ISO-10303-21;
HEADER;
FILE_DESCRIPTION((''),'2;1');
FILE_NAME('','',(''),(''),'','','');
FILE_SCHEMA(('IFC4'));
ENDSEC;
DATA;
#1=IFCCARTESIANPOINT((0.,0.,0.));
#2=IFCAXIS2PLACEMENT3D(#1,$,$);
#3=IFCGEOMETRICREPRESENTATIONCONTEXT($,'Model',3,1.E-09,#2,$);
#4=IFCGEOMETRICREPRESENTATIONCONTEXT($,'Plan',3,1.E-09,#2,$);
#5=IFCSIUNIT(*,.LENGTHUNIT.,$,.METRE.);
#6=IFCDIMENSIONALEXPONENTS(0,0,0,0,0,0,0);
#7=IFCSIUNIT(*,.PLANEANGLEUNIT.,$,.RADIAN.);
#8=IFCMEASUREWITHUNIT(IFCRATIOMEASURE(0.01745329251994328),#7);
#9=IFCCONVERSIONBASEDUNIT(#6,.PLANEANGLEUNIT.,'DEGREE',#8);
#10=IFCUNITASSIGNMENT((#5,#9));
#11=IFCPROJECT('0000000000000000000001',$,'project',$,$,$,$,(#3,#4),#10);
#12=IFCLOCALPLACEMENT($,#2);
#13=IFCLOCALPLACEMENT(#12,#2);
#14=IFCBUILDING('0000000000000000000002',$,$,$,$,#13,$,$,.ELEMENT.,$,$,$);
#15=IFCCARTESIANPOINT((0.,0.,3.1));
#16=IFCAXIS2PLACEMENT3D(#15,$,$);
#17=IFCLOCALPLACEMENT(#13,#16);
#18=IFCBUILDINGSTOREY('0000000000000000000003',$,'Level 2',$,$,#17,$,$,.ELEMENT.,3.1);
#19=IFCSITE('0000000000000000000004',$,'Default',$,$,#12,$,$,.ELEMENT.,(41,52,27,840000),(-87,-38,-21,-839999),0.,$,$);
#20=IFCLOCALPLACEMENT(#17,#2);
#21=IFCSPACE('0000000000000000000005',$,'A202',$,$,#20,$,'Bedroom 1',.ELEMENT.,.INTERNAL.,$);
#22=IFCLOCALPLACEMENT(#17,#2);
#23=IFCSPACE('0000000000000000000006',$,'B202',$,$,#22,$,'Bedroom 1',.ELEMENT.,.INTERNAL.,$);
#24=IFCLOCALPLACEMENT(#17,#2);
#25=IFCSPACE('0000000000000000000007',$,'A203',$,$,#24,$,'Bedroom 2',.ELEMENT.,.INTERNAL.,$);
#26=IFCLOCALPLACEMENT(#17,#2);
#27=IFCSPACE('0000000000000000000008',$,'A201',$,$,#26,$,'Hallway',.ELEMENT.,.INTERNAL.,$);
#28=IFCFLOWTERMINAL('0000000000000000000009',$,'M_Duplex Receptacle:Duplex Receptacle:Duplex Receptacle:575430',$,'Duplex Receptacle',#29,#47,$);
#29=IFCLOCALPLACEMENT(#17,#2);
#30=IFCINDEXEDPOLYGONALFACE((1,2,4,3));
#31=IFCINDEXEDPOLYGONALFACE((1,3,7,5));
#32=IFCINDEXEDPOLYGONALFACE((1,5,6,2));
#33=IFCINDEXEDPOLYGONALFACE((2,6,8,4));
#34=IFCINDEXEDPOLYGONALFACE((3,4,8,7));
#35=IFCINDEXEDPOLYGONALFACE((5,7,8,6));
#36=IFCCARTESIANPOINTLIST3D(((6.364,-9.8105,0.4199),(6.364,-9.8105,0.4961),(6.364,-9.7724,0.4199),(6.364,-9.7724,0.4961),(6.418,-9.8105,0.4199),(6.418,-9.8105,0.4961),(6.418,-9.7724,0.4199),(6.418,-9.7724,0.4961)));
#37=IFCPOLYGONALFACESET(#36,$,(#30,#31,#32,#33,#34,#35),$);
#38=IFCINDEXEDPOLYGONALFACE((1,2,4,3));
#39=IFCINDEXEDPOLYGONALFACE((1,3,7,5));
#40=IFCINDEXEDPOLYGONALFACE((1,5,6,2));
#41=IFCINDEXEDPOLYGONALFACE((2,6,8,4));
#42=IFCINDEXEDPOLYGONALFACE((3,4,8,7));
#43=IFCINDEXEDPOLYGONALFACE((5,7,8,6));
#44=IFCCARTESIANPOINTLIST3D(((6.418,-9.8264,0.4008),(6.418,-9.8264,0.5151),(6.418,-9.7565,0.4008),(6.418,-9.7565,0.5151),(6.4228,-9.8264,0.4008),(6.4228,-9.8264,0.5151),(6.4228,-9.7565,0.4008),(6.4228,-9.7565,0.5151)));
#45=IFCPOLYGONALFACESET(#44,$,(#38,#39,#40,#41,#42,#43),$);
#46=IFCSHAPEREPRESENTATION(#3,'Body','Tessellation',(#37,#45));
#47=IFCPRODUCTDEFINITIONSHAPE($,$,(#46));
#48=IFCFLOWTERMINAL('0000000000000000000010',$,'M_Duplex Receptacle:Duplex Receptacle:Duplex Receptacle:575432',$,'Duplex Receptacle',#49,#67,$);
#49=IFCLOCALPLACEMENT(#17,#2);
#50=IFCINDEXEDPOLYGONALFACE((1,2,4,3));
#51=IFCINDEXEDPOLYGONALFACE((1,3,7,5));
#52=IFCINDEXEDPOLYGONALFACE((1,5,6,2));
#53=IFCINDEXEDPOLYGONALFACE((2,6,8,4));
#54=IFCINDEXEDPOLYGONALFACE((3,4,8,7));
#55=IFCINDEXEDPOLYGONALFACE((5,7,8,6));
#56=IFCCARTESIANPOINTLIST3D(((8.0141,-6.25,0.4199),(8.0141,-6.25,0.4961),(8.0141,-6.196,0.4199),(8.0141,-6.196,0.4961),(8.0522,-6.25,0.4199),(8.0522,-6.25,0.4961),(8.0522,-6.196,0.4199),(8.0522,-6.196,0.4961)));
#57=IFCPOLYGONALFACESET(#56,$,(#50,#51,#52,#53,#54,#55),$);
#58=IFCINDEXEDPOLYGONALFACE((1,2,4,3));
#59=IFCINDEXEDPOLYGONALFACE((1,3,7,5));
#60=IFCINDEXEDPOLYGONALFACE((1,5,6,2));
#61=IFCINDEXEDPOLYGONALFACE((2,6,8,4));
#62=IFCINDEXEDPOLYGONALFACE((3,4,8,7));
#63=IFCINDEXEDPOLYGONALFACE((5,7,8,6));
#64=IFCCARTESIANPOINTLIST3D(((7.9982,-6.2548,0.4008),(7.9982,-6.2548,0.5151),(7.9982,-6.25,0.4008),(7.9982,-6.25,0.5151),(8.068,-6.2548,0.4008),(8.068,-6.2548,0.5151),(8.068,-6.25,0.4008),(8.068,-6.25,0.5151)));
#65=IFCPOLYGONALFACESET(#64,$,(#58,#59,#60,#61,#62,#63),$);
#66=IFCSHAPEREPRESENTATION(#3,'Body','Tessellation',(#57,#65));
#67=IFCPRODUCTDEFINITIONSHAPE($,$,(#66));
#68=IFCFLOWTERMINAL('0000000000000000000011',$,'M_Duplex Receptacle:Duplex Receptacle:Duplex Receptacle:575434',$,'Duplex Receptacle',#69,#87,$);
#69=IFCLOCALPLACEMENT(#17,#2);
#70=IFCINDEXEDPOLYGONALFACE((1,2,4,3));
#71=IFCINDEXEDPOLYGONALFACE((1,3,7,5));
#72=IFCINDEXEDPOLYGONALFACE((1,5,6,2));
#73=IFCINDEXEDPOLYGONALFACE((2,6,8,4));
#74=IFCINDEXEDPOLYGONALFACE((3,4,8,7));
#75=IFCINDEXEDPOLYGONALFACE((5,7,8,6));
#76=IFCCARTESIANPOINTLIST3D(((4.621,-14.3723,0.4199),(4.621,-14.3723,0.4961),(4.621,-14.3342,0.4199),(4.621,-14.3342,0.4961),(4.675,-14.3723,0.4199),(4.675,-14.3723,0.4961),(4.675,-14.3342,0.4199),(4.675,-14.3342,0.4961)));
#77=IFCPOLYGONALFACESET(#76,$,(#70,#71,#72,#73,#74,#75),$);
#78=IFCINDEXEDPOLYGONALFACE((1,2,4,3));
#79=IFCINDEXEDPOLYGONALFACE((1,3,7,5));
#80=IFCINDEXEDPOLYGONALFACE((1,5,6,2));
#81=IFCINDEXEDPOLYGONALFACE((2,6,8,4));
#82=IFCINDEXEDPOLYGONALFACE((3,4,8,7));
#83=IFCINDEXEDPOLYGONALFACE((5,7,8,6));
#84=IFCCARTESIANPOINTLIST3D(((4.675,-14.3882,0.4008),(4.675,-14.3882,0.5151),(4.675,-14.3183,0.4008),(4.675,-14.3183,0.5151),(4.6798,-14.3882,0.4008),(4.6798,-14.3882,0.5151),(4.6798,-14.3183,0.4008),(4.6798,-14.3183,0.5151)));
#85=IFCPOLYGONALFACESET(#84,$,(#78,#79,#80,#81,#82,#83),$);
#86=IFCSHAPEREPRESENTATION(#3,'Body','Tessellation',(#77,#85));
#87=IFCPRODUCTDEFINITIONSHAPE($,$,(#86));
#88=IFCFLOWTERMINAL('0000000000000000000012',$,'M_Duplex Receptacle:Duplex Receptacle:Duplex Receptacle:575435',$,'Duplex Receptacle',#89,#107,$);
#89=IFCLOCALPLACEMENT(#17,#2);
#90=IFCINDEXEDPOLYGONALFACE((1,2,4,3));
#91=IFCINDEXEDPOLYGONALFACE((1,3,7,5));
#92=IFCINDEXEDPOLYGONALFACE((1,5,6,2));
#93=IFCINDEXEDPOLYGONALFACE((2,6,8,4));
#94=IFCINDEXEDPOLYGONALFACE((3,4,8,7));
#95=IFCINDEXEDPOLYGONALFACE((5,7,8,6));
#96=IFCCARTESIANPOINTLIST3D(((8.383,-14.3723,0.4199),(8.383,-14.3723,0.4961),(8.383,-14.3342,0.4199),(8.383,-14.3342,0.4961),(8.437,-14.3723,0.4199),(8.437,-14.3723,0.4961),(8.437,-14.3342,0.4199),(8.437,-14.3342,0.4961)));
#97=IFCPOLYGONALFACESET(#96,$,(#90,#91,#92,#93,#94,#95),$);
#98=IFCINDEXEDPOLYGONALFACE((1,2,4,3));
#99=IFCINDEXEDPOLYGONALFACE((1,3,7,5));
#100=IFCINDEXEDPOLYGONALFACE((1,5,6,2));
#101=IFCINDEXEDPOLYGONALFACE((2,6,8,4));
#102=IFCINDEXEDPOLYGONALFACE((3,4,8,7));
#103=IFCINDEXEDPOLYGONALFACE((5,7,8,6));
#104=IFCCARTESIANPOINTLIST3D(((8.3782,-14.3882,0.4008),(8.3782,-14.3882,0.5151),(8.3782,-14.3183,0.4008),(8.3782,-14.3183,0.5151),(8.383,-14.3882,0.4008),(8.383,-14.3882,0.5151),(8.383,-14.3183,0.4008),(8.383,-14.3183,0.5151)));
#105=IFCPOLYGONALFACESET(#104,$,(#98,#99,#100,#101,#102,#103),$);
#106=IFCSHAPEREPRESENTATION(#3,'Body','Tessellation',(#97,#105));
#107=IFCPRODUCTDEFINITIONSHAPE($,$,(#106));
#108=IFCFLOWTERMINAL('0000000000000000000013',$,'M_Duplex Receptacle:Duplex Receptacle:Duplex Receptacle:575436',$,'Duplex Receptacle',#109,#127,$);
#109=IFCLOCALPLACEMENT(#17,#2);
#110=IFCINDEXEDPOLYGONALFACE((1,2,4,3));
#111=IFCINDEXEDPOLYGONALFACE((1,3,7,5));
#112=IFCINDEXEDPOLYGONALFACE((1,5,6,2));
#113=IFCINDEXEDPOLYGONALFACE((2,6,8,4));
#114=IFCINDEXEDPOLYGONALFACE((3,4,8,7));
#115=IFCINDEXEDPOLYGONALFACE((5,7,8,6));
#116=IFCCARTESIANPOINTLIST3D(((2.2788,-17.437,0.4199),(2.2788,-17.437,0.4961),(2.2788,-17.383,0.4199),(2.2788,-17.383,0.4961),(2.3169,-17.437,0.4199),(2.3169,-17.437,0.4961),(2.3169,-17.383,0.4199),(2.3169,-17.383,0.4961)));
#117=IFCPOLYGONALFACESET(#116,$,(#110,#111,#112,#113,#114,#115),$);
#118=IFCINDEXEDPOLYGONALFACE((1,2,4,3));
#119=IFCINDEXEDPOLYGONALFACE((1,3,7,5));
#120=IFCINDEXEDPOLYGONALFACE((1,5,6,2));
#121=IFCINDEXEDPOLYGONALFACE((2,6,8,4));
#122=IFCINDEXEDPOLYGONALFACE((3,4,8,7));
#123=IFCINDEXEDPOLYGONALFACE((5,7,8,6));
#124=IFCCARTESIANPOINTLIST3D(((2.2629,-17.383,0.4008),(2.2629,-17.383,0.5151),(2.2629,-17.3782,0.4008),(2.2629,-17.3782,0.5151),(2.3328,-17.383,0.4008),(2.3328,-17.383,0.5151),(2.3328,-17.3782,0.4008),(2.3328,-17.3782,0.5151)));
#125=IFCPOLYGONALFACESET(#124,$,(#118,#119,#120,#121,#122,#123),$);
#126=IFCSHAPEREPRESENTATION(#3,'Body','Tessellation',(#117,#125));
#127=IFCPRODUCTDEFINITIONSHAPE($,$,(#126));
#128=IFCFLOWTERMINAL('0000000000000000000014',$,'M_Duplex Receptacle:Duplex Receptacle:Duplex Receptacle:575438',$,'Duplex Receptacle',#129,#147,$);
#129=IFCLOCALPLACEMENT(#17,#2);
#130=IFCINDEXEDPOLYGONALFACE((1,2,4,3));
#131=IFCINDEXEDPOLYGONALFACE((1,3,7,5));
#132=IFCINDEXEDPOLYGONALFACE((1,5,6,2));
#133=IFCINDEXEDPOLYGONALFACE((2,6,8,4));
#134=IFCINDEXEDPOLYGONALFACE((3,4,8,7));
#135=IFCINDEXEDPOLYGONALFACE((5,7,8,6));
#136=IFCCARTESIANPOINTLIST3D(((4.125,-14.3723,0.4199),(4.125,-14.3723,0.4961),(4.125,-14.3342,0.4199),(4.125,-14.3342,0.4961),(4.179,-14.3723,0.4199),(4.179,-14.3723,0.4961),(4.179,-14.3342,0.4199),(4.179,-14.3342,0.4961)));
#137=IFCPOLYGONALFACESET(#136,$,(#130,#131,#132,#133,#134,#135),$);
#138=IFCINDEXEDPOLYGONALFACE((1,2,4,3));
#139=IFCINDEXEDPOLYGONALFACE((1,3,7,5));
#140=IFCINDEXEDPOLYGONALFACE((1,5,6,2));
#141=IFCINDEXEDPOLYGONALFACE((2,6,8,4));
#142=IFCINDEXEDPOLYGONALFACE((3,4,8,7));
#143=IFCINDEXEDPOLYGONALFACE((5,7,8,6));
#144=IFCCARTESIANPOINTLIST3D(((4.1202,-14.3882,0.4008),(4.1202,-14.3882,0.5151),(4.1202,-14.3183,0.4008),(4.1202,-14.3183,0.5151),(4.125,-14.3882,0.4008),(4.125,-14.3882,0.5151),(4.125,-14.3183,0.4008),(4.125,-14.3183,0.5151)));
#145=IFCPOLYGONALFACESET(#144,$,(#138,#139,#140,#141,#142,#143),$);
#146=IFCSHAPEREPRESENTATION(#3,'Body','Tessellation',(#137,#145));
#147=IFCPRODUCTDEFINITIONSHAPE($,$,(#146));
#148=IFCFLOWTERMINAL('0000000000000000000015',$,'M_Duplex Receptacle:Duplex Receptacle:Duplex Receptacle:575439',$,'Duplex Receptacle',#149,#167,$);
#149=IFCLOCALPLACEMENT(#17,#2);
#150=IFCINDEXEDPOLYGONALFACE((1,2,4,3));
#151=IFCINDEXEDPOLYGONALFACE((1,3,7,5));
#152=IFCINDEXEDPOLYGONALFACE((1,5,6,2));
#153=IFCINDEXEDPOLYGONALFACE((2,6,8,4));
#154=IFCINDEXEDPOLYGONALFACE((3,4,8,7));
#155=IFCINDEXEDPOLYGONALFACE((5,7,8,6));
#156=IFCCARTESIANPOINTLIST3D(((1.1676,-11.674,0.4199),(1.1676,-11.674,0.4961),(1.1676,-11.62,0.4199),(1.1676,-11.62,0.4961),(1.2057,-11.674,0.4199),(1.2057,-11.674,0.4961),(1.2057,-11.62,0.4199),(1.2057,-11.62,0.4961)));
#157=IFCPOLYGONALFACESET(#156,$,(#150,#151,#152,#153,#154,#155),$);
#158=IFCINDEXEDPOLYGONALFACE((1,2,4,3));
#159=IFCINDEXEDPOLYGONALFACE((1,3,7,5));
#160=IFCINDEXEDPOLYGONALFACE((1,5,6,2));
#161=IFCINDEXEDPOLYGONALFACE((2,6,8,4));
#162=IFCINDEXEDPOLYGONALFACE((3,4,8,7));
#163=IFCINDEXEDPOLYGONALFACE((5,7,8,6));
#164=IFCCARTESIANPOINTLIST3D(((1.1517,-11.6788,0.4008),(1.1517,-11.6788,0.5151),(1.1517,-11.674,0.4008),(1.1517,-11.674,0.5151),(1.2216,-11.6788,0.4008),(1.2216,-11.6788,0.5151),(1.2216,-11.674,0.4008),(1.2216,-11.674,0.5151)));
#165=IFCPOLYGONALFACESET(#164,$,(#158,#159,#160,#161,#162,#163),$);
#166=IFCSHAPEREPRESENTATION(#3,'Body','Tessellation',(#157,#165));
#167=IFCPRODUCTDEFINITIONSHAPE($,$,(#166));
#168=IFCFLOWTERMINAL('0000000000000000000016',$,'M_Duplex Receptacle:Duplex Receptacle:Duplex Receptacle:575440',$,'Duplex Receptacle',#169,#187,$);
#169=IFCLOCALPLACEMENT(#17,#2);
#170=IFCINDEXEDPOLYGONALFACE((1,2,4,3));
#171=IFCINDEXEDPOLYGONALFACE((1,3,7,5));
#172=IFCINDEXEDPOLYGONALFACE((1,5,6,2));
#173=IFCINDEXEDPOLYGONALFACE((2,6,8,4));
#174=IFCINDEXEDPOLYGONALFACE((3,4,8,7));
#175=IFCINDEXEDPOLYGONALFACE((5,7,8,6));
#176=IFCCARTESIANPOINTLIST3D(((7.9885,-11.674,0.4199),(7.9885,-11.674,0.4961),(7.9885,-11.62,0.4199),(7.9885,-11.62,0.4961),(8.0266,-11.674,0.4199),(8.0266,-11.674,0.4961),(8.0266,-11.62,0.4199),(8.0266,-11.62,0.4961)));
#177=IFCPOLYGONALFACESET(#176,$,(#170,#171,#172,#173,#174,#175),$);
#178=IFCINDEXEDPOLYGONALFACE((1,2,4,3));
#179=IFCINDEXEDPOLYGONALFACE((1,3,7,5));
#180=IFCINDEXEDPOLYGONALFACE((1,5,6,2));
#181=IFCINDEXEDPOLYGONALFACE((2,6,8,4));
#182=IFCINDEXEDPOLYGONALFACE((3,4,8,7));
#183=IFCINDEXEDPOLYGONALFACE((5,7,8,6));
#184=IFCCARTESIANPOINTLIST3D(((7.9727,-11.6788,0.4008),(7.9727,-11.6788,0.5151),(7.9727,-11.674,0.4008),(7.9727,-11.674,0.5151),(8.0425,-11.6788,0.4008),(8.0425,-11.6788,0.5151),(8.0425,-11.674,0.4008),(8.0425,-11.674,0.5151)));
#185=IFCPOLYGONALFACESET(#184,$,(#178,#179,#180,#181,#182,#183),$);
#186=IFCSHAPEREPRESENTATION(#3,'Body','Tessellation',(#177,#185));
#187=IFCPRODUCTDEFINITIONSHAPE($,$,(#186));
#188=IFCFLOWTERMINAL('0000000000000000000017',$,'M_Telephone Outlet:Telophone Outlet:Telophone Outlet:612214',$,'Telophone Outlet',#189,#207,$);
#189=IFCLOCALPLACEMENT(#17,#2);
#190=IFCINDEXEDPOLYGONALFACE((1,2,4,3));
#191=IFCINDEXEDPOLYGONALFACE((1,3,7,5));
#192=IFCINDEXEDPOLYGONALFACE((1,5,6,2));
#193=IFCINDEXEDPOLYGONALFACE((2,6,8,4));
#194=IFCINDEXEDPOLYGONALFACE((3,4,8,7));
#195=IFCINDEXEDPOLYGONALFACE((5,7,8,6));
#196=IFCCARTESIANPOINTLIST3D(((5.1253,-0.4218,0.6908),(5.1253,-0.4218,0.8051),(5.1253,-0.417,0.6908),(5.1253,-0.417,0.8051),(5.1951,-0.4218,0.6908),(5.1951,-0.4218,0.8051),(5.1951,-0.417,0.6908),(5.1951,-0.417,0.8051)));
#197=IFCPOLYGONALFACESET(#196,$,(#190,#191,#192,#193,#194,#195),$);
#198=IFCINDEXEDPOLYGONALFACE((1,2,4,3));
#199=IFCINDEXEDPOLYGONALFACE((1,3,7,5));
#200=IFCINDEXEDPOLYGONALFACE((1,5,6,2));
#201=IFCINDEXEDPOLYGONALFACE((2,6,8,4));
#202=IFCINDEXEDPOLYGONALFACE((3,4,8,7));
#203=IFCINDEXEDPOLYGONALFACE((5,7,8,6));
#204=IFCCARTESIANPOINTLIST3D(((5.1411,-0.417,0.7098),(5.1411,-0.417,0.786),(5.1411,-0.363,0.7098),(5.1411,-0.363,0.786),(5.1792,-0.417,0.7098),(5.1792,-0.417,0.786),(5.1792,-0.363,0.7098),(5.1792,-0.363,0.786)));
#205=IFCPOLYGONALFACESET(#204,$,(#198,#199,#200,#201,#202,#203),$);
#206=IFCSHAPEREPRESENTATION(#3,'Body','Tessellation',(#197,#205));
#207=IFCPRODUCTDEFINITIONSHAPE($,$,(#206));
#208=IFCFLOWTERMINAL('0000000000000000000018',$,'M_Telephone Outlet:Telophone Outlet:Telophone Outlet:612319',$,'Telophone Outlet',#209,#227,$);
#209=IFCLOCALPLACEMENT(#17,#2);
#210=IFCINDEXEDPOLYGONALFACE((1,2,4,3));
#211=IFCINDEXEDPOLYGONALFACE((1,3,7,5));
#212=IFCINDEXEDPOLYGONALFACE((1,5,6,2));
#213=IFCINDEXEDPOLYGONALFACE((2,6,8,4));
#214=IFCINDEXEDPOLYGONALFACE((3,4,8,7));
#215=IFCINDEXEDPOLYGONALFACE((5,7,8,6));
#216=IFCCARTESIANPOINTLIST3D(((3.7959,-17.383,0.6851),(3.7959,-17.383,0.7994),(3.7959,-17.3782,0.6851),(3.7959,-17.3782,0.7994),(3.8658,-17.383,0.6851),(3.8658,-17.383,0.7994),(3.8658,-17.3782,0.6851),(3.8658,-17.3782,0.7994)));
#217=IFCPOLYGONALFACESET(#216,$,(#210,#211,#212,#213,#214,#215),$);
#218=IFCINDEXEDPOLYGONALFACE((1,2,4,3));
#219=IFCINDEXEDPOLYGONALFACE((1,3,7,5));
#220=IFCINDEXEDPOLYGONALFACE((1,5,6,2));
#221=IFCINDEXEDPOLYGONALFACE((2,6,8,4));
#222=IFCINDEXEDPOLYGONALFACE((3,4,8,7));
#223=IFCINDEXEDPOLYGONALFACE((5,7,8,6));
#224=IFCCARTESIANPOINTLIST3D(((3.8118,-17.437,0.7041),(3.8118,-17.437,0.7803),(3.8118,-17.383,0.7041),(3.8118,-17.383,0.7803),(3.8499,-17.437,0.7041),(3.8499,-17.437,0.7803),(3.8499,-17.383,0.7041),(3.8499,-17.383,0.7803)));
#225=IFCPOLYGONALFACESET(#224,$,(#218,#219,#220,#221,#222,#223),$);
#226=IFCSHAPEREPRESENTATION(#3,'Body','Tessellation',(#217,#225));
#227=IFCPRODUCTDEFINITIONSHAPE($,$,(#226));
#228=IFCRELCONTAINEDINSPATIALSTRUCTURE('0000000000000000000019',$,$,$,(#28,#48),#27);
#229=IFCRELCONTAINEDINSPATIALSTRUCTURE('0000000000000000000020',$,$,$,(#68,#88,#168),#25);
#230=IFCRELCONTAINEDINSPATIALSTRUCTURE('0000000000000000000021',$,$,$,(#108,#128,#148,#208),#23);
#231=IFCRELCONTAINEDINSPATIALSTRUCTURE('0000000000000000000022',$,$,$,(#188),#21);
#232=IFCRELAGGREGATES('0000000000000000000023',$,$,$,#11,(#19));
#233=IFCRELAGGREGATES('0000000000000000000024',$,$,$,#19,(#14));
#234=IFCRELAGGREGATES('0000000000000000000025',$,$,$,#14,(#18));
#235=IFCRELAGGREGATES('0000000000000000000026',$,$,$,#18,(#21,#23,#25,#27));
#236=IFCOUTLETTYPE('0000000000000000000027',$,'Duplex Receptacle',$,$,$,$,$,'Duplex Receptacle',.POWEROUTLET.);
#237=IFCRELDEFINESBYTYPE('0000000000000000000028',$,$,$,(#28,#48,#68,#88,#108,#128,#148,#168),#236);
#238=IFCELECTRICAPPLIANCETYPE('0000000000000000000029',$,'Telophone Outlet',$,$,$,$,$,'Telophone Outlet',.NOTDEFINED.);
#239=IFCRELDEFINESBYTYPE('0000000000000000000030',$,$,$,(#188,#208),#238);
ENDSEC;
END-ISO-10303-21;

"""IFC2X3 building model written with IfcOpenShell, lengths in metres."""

from ifc_helpers import new_model, entity, si_unit, converted_unit, frame, origin, origin_2d_with_axis, place, context, project, spatial, rectangle, extrude, source, transform, mapped, type_object, type_shapes, element, save


model = new_model("IFC2X3")

# Units and contexts
model_context = context("Model", 3, precision=1e-09, world=origin())
plan_context = context("Plan", 3, precision=1e-09, world=origin())
ifc_project = project(units=[si_unit("LENGTHUNIT", "METRE"), converted_unit("PLANEANGLEUNIT", "DEGREE", entity("IfcRatioMeasure", 0.01745329251994328), si_unit("PLANEANGLEUNIT", "RADIAN"), dimensions=[0, 0, 0, 0, 0, 0, 0])], contexts=[model_context, plan_context])

# Site, building, storey, space
site_placement = place(None, origin())
site = spatial("IfcSite", under=ifc_project, at=site_placement, Name="Default", CompositionType="ELEMENT", RefLatitude=(41, 52, 27, 840000), RefLongitude=(-87, -38, -21, -839999), RefElevation=0.0)
building_placement = place(site_placement, origin())
building = spatial("IfcBuilding", under=site, at=building_placement, CompositionType="ELEMENT")
storey_placement = place(building_placement, frame((0.0, 0.0, 3.1)))
storey = spatial("IfcBuildingStorey", under=building, at=storey_placement, Name="Level 2", CompositionType="ELEMENT", Elevation=3.1)
space_1_placement = place(storey_placement, origin())
space_1 = spatial("IfcSpace", under=storey, at=space_1_placement, Name="A202", LongName="Bedroom 1", CompositionType="ELEMENT", InteriorOrExteriorSpace="INTERNAL")

# Shared definitions
space_2_placement = place(storey_placement, origin())
space_2 = spatial("IfcSpace", under=storey, at=space_2_placement, Name="B202", LongName="Bedroom 1", CompositionType="ELEMENT", InteriorOrExteriorSpace="INTERNAL")

# Shared definitions
space_3_placement = place(storey_placement, origin())
space_3 = spatial("IfcSpace", under=storey, at=space_3_placement, Name="A203", LongName="Bedroom 2", CompositionType="ELEMENT", InteriorOrExteriorSpace="INTERNAL")

# Shared definitions
space_4_placement = place(storey_placement, origin())
space_4 = spatial("IfcSpace", under=storey, at=space_4_placement, Name="A201", LongName="Hallway", CompositionType="ELEMENT", InteriorOrExteriorSpace="INTERNAL")

# Flow terminals
outlet_type = type_object("IfcOutletType", Name="Duplex Receptacle", ElementType="Duplex Receptacle", PredefinedType="POWEROUTLET")
shared_shape_1 = source(origin(), model_context, "Body", "SweptSolid", [
    extrude(rectangle(XDim=0.0381, YDim=0.0762, at=origin_2d_with_axis()), frame((0.0, 0.0, -0.054), z_axis=(0.0, 0.0, 1.0), x_axis=(-1.0, 0.0, 0.0)), (0.0, 0.0, 1.0), 0.054),
    extrude(rectangle(XDim=0.0698, YDim=0.1143, at=origin_2d_with_axis()), frame((0.0, 0.0, 0.0), z_axis=(0.0, 0.0, 1.0), x_axis=(-1.0, 0.0, 0.0)), (0.0, 0.0, 1.0), 0.0048),
])
type_shapes(outlet_type, [shared_shape_1])
for number, where, z_axis, x_axis, name in (
    (1, (6.418, -9.7914, 0.458), (1.0, 0.0, 0.0), (0.0, 1.0, 0.0), "M_Duplex Receptacle:Duplex Receptacle:Duplex Receptacle:575430"),
    (2, (8.0331, -6.25, 0.458), (0.0, -1.0, 0.0), (1.0, 0.0, 0.0), "M_Duplex Receptacle:Duplex Receptacle:Duplex Receptacle:575432"),
):
    element("IfcFlowTerminal", number, at=place(space_4_placement, frame(where, z_axis=z_axis, x_axis=x_axis)), inside=space_4, type_object=outlet_type, Name=name, ObjectType="Duplex Receptacle", context=model_context, shape_type="MappedRepresentation", body=[
        mapped(shared_shape_1, transform((0.0, 0.0, 0.0), scale=1.0)),
    ])
for number, where, z_axis, x_axis, name in (
    (3, (4.675, -14.3533, 0.458), (1.0, 0.0, 0.0), (0.0, 1.0, 0.0), "M_Duplex Receptacle:Duplex Receptacle:Duplex Receptacle:575434"),
    (4, (8.383, -14.3533, 0.458), (-1.0, 0.0, 0.0), (0.0, -1.0, 0.0), "M_Duplex Receptacle:Duplex Receptacle:Duplex Receptacle:575435"),
):
    element("IfcFlowTerminal", number, at=place(space_3_placement, frame(where, z_axis=z_axis, x_axis=x_axis)), inside=space_3, type_object=outlet_type, Name=name, ObjectType="Duplex Receptacle", context=model_context, shape_type="MappedRepresentation", body=[
        mapped(shared_shape_1, transform((0.0, 0.0, 0.0), scale=1.0)),
    ])
for number, where, z_axis, x_axis, name in (
    (5, (2.2979, -17.383, 0.458), (0.0, 1.0, 0.0), (-1.0, 0.0, 0.0), "M_Duplex Receptacle:Duplex Receptacle:Duplex Receptacle:575436"),
    (6, (4.125, -14.3533, 0.458), (-1.0, 0.0, 0.0), (0.0, -1.0, 0.0), "M_Duplex Receptacle:Duplex Receptacle:Duplex Receptacle:575438"),
    (7, (1.1866, -11.674, 0.458), (0.0, -1.0, 0.0), (1.0, 0.0, 0.0), "M_Duplex Receptacle:Duplex Receptacle:Duplex Receptacle:575439"),
):
    element("IfcFlowTerminal", number, at=place(space_2_placement, frame(where, z_axis=z_axis, x_axis=x_axis)), inside=space_2, type_object=outlet_type, Name=name, ObjectType="Duplex Receptacle", context=model_context, shape_type="MappedRepresentation", body=[
        mapped(shared_shape_1, transform((0.0, 0.0, 0.0), scale=1.0)),
    ])
flow_terminal_1_placement = place(space_3_placement, frame((8.0076, -11.674, 0.458), z_axis=(0.0, -1.0, 0.0), x_axis=(1.0, 0.0, 0.0)))
element("IfcFlowTerminal", 8, at=flow_terminal_1_placement, inside=space_3, type_object=outlet_type, Name="M_Duplex Receptacle:Duplex Receptacle:Duplex Receptacle:575440", ObjectType="Duplex Receptacle", context=model_context, shape_type="MappedRepresentation", body=[
    mapped(shared_shape_1, transform((0.0, 0.0, 0.0), scale=1.0)),
])
electric_appliance_type = type_object("IfcElectricApplianceType", Name="Telophone Outlet", ElementType="Telophone Outlet", PredefinedType="NOTDEFINED")
shared_shape_2 = source(origin(), model_context, "Body", "SweptSolid", [
    extrude(rectangle(XDim=0.0699, YDim=0.1143, at=origin_2d_with_axis()), frame((0.0, 0.0, 0.0), z_axis=(0.0, 0.0, 1.0), x_axis=(-1.0, 0.0, 0.0)), (0.0, 0.0, 1.0), 0.0048),
    extrude(rectangle(XDim=0.0381, YDim=0.0762, at=origin_2d_with_axis()), frame((0.0, 0.0, -0.054), z_axis=(0.0, 0.0, 1.0), x_axis=(-1.0, 0.0, 0.0)), (0.0, 0.0, 1.0), 0.054),
])
type_shapes(electric_appliance_type, [shared_shape_2])
flow_terminal_2_placement = place(space_1_placement, frame((5.1602, -0.417, 0.7479), z_axis=(0.0, -1.0, 0.0), x_axis=(1.0, 0.0, 0.0)))
element("IfcFlowTerminal", 9, at=flow_terminal_2_placement, inside=space_1, type_object=electric_appliance_type, Name="M_Telephone Outlet:Telophone Outlet:Telophone Outlet:612214", ObjectType="Telophone Outlet", context=model_context, shape_type="MappedRepresentation", body=[
    mapped(shared_shape_2, transform((0.0, 0.0, 0.0), scale=1.0)),
])
flow_terminal_3_placement = place(space_2_placement, frame((3.8309, -17.383, 0.7422), z_axis=(0.0, 1.0, 0.0), x_axis=(-1.0, 0.0, 0.0)))
element("IfcFlowTerminal", 10, at=flow_terminal_3_placement, inside=space_2, type_object=electric_appliance_type, Name="M_Telephone Outlet:Telophone Outlet:Telophone Outlet:612319", ObjectType="Telophone Outlet", context=model_context, shape_type="MappedRepresentation", body=[
    mapped(shared_shape_2, transform((0.0, 0.0, 0.0), scale=1.0)),
])

save(model, "model.ifc")
